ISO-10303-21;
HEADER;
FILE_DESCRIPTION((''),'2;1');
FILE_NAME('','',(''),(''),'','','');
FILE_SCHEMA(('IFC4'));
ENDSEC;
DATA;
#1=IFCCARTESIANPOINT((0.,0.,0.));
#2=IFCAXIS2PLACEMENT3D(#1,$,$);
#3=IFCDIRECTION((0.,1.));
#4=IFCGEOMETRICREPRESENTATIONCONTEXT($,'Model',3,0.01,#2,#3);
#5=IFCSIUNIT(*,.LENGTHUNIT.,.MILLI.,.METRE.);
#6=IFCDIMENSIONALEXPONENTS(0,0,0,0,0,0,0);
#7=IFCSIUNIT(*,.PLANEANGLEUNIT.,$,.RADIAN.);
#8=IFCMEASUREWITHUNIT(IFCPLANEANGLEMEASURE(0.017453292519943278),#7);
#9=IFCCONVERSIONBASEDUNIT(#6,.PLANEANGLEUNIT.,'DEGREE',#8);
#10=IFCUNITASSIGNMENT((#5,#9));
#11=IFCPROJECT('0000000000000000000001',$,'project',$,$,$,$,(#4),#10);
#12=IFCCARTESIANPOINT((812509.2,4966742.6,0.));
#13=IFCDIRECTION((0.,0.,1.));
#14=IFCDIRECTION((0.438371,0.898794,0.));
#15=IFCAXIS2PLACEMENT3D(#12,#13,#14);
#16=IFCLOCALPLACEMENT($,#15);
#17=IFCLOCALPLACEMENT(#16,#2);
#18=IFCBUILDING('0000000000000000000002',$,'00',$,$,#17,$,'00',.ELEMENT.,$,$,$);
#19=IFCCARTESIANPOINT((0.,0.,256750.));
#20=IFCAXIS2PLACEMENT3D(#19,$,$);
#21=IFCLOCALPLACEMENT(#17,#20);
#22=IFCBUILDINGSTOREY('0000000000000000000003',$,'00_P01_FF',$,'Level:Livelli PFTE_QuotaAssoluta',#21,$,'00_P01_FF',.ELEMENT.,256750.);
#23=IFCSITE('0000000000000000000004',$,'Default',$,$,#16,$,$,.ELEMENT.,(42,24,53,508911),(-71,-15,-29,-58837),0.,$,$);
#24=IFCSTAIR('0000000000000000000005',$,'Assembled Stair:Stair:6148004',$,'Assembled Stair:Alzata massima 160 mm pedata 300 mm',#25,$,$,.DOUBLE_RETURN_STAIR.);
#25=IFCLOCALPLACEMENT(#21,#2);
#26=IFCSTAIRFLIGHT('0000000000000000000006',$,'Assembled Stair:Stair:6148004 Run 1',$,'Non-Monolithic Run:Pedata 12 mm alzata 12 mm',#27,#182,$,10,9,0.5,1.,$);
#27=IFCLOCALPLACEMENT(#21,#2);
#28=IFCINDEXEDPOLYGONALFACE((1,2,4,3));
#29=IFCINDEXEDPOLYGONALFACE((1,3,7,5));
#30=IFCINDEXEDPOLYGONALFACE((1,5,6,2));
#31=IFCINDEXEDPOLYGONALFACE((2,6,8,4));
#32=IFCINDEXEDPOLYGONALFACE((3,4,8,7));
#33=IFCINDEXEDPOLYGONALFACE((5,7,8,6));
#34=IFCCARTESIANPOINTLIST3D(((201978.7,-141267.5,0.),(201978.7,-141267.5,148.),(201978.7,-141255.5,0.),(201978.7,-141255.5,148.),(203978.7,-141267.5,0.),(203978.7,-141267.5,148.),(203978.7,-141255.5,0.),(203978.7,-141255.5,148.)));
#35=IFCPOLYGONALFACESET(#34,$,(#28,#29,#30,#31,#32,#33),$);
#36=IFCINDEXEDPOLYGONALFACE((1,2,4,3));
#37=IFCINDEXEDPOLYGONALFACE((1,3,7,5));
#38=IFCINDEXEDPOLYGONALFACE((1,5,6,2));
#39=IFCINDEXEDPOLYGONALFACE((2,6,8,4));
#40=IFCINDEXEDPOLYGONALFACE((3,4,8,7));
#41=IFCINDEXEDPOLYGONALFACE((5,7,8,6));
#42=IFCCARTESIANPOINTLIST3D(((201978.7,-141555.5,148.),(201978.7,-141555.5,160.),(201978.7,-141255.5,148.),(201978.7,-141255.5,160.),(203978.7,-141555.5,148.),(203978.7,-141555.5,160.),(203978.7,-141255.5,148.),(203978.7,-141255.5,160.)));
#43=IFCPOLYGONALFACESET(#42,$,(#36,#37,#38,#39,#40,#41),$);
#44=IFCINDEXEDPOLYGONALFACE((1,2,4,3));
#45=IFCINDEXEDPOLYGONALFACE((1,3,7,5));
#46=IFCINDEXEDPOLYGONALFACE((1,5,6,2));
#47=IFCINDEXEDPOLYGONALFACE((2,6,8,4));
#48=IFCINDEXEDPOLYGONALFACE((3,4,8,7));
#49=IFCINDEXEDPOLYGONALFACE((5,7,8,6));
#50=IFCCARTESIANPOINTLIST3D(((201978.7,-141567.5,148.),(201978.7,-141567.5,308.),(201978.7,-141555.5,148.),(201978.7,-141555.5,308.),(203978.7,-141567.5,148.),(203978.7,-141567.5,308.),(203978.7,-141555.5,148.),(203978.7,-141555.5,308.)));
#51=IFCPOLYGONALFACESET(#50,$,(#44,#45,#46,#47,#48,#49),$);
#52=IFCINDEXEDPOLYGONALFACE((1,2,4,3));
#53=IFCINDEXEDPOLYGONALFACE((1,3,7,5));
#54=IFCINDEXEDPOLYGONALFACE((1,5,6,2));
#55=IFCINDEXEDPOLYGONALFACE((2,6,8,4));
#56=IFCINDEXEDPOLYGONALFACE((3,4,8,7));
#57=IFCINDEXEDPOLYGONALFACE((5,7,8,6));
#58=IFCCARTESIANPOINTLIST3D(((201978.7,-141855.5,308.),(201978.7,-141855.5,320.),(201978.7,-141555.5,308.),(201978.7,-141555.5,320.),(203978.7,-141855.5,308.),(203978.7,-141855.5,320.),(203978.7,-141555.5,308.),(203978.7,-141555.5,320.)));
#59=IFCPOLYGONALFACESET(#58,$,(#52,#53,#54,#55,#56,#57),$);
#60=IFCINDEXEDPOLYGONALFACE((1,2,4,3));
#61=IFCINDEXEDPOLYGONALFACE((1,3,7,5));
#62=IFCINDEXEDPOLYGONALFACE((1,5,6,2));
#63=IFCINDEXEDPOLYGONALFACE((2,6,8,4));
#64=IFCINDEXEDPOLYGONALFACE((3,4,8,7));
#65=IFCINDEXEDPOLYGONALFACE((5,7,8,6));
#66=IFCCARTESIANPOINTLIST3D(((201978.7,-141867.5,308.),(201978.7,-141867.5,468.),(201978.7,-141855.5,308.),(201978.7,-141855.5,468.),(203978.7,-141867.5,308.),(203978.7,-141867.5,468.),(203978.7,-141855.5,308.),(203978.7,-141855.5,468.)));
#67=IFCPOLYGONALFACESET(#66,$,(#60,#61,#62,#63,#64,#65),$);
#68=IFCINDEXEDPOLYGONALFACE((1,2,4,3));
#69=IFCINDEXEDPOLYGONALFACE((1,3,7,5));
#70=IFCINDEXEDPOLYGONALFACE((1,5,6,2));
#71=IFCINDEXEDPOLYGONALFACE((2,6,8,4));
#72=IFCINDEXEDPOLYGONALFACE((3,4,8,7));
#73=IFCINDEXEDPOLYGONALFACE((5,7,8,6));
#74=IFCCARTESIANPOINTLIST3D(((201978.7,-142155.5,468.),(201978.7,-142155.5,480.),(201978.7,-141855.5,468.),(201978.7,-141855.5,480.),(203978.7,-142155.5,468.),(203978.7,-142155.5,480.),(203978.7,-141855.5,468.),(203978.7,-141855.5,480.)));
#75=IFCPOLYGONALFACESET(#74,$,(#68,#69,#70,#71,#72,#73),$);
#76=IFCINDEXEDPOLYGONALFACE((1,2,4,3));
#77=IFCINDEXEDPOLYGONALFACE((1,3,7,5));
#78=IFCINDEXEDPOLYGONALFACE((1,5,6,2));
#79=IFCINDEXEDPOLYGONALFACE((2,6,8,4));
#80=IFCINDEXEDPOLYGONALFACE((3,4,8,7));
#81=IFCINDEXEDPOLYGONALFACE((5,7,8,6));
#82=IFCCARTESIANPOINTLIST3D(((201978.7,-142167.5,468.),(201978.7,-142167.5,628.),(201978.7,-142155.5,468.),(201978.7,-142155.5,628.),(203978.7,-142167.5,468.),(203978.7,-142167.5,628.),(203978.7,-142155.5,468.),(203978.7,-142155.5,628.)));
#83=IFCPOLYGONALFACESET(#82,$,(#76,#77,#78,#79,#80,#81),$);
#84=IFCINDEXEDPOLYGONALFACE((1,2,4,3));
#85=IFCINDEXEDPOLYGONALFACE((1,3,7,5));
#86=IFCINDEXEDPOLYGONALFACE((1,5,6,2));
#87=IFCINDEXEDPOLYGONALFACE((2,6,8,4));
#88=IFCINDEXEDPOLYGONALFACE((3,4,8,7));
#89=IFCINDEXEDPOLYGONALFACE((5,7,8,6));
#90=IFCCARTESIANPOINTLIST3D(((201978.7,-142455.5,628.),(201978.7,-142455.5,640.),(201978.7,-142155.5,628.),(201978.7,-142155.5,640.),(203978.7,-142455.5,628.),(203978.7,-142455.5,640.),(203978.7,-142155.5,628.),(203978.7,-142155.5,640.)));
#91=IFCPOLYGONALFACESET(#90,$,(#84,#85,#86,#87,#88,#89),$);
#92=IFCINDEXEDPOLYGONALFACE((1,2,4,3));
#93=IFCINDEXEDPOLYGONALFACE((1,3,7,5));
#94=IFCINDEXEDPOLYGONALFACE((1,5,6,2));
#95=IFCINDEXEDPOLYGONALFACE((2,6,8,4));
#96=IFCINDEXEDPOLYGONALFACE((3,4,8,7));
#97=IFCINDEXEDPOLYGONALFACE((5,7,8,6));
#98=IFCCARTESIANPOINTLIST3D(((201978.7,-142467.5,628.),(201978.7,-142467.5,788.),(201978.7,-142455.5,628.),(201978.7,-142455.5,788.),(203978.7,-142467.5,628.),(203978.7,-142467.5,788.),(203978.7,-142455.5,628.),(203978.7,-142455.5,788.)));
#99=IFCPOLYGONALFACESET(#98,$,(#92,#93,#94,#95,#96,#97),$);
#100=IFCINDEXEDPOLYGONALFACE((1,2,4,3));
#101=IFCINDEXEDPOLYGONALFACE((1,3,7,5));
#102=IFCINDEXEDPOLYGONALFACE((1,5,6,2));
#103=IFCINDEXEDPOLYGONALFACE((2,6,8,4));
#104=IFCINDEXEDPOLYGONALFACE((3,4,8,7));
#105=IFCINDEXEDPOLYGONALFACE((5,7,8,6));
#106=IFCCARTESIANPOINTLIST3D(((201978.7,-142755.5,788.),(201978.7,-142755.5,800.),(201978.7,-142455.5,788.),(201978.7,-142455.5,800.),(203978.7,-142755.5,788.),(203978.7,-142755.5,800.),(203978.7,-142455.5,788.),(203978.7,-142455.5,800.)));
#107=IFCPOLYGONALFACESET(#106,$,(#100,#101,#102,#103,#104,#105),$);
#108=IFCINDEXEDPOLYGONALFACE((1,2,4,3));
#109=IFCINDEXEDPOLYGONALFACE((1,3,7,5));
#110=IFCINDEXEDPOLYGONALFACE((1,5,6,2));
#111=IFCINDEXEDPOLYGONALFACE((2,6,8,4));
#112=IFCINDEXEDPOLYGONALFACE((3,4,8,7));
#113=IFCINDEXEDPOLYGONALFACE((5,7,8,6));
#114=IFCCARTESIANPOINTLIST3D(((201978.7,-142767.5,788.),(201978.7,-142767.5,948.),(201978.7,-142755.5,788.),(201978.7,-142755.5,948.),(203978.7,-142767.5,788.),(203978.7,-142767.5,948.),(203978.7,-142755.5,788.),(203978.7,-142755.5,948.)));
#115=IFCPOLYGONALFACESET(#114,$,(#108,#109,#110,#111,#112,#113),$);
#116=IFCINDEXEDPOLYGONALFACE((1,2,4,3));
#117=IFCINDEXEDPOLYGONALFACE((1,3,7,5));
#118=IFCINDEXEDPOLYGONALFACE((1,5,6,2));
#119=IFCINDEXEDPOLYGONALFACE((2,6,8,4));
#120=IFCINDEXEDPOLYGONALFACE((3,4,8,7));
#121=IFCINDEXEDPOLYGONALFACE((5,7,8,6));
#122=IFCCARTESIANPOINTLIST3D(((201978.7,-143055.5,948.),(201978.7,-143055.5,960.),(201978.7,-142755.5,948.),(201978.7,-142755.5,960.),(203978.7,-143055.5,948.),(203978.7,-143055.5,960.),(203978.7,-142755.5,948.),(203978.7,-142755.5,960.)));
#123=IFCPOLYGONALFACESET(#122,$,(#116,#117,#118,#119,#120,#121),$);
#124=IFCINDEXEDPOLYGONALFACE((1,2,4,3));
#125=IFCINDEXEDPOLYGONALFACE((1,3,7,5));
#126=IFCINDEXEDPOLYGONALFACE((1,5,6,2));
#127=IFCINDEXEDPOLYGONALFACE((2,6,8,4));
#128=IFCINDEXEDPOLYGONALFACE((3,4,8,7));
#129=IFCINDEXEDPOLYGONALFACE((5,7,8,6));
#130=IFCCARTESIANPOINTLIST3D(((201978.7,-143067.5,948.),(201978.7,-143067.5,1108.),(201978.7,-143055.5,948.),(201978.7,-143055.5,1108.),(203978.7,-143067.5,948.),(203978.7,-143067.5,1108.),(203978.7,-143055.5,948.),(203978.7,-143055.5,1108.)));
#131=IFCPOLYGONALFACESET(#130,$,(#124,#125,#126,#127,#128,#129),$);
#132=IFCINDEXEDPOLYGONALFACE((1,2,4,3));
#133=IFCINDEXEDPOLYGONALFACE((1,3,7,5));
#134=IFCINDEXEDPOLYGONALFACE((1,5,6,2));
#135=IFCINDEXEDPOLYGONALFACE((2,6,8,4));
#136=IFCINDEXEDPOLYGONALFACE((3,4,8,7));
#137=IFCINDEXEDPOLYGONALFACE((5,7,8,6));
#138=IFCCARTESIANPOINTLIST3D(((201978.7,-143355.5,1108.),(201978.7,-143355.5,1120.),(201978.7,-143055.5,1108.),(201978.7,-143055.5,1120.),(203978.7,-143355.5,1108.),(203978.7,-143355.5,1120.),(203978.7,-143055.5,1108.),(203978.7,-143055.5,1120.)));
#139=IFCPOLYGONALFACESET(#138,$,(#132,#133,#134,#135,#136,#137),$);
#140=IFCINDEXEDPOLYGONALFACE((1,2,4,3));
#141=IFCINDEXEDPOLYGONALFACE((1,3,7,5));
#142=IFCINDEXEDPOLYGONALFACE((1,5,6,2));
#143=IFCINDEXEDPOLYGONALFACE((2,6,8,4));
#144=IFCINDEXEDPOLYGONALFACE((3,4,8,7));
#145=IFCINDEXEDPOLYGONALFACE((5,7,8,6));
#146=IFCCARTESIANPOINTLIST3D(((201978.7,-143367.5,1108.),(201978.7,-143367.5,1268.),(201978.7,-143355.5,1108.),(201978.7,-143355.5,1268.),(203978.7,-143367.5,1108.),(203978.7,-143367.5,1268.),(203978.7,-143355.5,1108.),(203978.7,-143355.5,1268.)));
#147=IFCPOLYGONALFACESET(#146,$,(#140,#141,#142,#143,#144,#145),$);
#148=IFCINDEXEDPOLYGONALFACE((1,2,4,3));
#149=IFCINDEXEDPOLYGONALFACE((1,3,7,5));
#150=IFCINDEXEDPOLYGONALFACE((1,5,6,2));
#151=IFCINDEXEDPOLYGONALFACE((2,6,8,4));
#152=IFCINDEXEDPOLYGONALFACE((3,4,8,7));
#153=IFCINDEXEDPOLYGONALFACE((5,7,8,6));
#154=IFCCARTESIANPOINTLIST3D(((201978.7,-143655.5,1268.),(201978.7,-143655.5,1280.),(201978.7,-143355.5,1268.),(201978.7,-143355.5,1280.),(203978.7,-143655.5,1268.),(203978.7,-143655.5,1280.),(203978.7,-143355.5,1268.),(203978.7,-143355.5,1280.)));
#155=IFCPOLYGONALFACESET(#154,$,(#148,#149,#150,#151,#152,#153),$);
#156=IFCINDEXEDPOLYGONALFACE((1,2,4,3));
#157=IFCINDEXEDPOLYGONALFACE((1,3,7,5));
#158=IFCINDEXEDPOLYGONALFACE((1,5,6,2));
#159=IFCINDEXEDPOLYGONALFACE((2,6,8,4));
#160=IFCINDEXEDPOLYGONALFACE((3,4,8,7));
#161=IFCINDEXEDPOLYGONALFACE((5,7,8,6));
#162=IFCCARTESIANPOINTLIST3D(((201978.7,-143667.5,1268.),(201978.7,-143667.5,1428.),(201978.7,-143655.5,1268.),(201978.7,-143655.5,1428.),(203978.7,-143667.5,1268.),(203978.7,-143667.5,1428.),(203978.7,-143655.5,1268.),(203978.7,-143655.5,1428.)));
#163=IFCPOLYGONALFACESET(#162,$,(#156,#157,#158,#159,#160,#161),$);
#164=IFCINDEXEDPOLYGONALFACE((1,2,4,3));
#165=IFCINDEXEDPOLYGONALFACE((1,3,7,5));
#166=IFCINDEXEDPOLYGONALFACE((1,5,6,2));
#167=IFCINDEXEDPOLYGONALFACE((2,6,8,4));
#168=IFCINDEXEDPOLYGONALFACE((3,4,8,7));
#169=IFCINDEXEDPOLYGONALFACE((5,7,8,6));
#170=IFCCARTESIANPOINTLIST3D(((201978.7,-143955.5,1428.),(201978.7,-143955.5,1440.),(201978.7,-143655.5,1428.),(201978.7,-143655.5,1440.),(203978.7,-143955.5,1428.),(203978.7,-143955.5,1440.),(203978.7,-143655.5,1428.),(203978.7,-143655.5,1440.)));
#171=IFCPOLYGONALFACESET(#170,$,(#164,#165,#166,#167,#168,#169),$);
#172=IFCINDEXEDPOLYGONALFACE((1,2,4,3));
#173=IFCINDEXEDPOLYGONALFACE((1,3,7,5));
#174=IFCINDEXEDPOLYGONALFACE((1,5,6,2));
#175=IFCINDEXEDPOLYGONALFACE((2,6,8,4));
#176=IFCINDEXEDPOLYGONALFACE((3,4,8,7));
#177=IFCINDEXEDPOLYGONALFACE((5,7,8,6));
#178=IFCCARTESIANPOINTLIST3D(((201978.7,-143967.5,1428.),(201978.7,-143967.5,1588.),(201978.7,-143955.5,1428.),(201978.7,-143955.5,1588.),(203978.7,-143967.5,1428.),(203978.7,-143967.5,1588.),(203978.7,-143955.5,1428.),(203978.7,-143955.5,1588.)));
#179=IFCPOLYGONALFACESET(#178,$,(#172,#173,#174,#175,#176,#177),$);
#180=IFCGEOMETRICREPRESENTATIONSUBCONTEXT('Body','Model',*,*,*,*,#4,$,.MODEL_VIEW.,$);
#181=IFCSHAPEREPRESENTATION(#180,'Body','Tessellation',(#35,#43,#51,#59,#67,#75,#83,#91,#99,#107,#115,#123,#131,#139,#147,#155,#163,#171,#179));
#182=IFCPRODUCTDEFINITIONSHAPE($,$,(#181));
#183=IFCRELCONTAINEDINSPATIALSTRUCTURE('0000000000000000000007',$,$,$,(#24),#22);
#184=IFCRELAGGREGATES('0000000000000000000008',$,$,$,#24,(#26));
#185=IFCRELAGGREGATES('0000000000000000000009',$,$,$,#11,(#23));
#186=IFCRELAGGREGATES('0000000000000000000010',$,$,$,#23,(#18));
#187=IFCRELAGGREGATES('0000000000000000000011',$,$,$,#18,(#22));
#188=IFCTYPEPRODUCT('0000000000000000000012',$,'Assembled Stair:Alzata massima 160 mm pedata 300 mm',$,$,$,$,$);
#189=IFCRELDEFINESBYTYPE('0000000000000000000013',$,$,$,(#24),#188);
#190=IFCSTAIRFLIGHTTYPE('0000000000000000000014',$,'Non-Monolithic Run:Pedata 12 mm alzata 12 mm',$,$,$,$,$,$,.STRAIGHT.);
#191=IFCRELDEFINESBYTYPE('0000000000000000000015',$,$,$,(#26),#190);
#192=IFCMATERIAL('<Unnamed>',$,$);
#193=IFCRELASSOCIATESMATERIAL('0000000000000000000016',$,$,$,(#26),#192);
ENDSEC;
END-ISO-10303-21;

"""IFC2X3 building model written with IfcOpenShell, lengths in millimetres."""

from ifc_helpers import new_model, entity, si_unit, converted_unit, direction, frame, frame_2d, origin, origin_2d_with_axis, place, context, subcontext, project, spatial, rectangle, extrude, material, type_object, element, aggregate, save


model = new_model("IFC2X3")

# Units and contexts
model_context = context("Model", 3, precision=0.01, world=origin(), true_north=direction((0.0, 1.0)))
body_context = subcontext(model_context, "Body", "Model", "MODEL_VIEW")
ifc_project = project(units=[si_unit("LENGTHUNIT", "METRE", prefix="MILLI"), converted_unit("PLANEANGLEUNIT", "DEGREE", entity("IfcPlaneAngleMeasure", 0.017453292519943278), si_unit("PLANEANGLEUNIT", "RADIAN"), dimensions=[0, 0, 0, 0, 0, 0, 0])], contexts=[model_context])

# Site, building, storey
site_placement = place(None, frame((812509.2, 4966742.6, 0.0), z_axis=(0.0, 0.0, 1.0), x_axis=(0.438371, 0.898794, 0.0)))
site = spatial("IfcSite", under=ifc_project, at=site_placement, Name="Default", CompositionType="ELEMENT", RefLatitude=(42, 24, 53, 508911), RefLongitude=(-71, -15, -29, -58837), RefElevation=0.0)
building_placement = place(site_placement, origin())
building = spatial("IfcBuilding", under=site, at=building_placement, Name="00", LongName="00", CompositionType="ELEMENT")
storey_placement = place(building_placement, frame((0.0, 0.0, 256750.0)))
storey = spatial("IfcBuildingStorey", under=building, at=storey_placement, Name="00_P01_FF", ObjectType="Level:Livelli PFTE_QuotaAssoluta", LongName="00_P01_FF", CompositionType="ELEMENT", Elevation=256750.0)

# Stair
type_product = type_object("IfcTypeProduct", Name="Assembled Stair:Alzata massima 160 mm pedata 300 mm")
ifc_material = material(Name="<Unnamed>")
stair_1_placement = place(storey_placement, origin())
stair_1 = element("IfcStair", 1, at=stair_1_placement, inside=storey, type_object=type_product, Name="Assembled Stair:Stair:6148004", ObjectType="Assembled Stair:Alzata massima 160 mm pedata 300 mm", ShapeType="DOUBLE_RETURN_STAIR")

# Stair flight
stair_flight_type = type_object("IfcStairFlightType", Name="Non-Monolithic Run:Pedata 12 mm alzata 12 mm", PredefinedType="STRAIGHT")
stair_flight_1_placement = place(stair_1_placement, origin())
stair_flight_1 = element("IfcStairFlight", 2, at=stair_flight_1_placement, type_object=stair_flight_type, material=ifc_material, Name="Assembled Stair:Stair:6148004 Run 1", ObjectType="Non-Monolithic Run:Pedata 12 mm alzata 12 mm", NumberOfRiser=10, NumberOfTreads=9, RiserHeight=0.5, TreadLength=1.0, context=body_context, shape_type="SweptSolid", body=[
    extrude(rectangle(XDim=2000.0, YDim=12.0, at=origin_2d_with_axis()), frame((202978.7, -141261.5, 0.0)), (0.0, 0.0, 1.0), 148.0),
    extrude(rectangle(XDim=300.0, YDim=2000.0, at=frame_2d((0.0, 0.0), x_axis=(1.0, 0.0))), frame((202978.7, -141405.5, 148.0), z_axis=(0.0, 0.0, 1.0), x_axis=(0.0, 1.0, 0.0)), (0.0, 0.0, 1.0), 12.0),
    extrude(rectangle(XDim=2000.0, YDim=12.0, at=origin_2d_with_axis()), frame((202978.7, -141561.5, 148.0)), (0.0, 0.0, 1.0), 160.0),
    extrude(rectangle(XDim=300.0, YDim=2000.0, at=origin_2d_with_axis()), frame((202978.7, -141705.5, 308.0), z_axis=(0.0, 0.0, 1.0), x_axis=(0.0, 1.0, 0.0)), (0.0, 0.0, 1.0), 12.0),
    extrude(rectangle(XDim=2000.0, YDim=12.0, at=origin_2d_with_axis()), frame((202978.7, -141861.5, 308.0)), (0.0, 0.0, 1.0), 160.0),
    extrude(rectangle(XDim=300.0, YDim=2000.0, at=origin_2d_with_axis()), frame((202978.7, -142005.5, 468.0), z_axis=(0.0, 0.0, 1.0), x_axis=(0.0, 1.0, 0.0)), (0.0, 0.0, 1.0), 12.0),
    extrude(rectangle(XDim=2000.0, YDim=12.0, at=origin_2d_with_axis()), frame((202978.7, -142161.5, 468.0)), (0.0, 0.0, 1.0), 160.0),
    extrude(rectangle(XDim=300.0, YDim=2000.0, at=origin_2d_with_axis()), frame((202978.7, -142305.5, 628.0), z_axis=(0.0, 0.0, 1.0), x_axis=(0.0, 1.0, 0.0)), (0.0, 0.0, 1.0), 12.0),
    extrude(rectangle(XDim=2000.0, YDim=12.0, at=origin_2d_with_axis()), frame((202978.7, -142461.5, 628.0)), (0.0, 0.0, 1.0), 160.0),
    extrude(rectangle(XDim=300.0, YDim=2000.0, at=origin_2d_with_axis()), frame((202978.7, -142605.5, 788.0), z_axis=(0.0, 0.0, 1.0), x_axis=(0.0, 1.0, 0.0)), (0.0, 0.0, 1.0), 12.0),
    extrude(rectangle(XDim=2000.0, YDim=12.0, at=origin_2d_with_axis()), frame((202978.7, -142761.5, 788.0)), (0.0, 0.0, 1.0), 160.0),
    extrude(rectangle(XDim=300.0, YDim=2000.0, at=origin_2d_with_axis()), frame((202978.7, -142905.5, 948.0), z_axis=(0.0, 0.0, 1.0), x_axis=(0.0, 1.0, 0.0)), (0.0, 0.0, 1.0), 12.0),
    extrude(rectangle(XDim=2000.0, YDim=12.0, at=origin_2d_with_axis()), frame((202978.7, -143061.5, 948.0)), (0.0, 0.0, 1.0), 160.0),
    extrude(rectangle(XDim=300.0, YDim=2000.0, at=origin_2d_with_axis()), frame((202978.7, -143205.5, 1108.0), z_axis=(0.0, 0.0, 1.0), x_axis=(0.0, 1.0, 0.0)), (0.0, 0.0, 1.0), 12.0),
    extrude(rectangle(XDim=2000.0, YDim=12.0, at=origin_2d_with_axis()), frame((202978.7, -143361.5, 1108.0)), (0.0, 0.0, 1.0), 160.0),
    extrude(rectangle(XDim=300.0, YDim=2000.0, at=origin_2d_with_axis()), frame((202978.7, -143505.5, 1268.0), z_axis=(0.0, 0.0, 1.0), x_axis=(0.0, 1.0, 0.0)), (0.0, 0.0, 1.0), 12.0),
    extrude(rectangle(XDim=2000.0, YDim=12.0, at=origin_2d_with_axis()), frame((202978.7, -143661.5, 1268.0)), (0.0, 0.0, 1.0), 160.0),
    extrude(rectangle(XDim=300.0, YDim=2000.0, at=origin_2d_with_axis()), frame((202978.7, -143805.5, 1428.0), z_axis=(0.0, 0.0, 1.0), x_axis=(0.0, 1.0, 0.0)), (0.0, 0.0, 1.0), 12.0),
    extrude(rectangle(XDim=2000.0, YDim=12.0, at=origin_2d_with_axis()), frame((202978.7, -143961.5, 1428.0)), (0.0, 0.0, 1.0), 160.0),
])
aggregate(stair_1, [stair_flight_1])

save(model, "model.ifc")
